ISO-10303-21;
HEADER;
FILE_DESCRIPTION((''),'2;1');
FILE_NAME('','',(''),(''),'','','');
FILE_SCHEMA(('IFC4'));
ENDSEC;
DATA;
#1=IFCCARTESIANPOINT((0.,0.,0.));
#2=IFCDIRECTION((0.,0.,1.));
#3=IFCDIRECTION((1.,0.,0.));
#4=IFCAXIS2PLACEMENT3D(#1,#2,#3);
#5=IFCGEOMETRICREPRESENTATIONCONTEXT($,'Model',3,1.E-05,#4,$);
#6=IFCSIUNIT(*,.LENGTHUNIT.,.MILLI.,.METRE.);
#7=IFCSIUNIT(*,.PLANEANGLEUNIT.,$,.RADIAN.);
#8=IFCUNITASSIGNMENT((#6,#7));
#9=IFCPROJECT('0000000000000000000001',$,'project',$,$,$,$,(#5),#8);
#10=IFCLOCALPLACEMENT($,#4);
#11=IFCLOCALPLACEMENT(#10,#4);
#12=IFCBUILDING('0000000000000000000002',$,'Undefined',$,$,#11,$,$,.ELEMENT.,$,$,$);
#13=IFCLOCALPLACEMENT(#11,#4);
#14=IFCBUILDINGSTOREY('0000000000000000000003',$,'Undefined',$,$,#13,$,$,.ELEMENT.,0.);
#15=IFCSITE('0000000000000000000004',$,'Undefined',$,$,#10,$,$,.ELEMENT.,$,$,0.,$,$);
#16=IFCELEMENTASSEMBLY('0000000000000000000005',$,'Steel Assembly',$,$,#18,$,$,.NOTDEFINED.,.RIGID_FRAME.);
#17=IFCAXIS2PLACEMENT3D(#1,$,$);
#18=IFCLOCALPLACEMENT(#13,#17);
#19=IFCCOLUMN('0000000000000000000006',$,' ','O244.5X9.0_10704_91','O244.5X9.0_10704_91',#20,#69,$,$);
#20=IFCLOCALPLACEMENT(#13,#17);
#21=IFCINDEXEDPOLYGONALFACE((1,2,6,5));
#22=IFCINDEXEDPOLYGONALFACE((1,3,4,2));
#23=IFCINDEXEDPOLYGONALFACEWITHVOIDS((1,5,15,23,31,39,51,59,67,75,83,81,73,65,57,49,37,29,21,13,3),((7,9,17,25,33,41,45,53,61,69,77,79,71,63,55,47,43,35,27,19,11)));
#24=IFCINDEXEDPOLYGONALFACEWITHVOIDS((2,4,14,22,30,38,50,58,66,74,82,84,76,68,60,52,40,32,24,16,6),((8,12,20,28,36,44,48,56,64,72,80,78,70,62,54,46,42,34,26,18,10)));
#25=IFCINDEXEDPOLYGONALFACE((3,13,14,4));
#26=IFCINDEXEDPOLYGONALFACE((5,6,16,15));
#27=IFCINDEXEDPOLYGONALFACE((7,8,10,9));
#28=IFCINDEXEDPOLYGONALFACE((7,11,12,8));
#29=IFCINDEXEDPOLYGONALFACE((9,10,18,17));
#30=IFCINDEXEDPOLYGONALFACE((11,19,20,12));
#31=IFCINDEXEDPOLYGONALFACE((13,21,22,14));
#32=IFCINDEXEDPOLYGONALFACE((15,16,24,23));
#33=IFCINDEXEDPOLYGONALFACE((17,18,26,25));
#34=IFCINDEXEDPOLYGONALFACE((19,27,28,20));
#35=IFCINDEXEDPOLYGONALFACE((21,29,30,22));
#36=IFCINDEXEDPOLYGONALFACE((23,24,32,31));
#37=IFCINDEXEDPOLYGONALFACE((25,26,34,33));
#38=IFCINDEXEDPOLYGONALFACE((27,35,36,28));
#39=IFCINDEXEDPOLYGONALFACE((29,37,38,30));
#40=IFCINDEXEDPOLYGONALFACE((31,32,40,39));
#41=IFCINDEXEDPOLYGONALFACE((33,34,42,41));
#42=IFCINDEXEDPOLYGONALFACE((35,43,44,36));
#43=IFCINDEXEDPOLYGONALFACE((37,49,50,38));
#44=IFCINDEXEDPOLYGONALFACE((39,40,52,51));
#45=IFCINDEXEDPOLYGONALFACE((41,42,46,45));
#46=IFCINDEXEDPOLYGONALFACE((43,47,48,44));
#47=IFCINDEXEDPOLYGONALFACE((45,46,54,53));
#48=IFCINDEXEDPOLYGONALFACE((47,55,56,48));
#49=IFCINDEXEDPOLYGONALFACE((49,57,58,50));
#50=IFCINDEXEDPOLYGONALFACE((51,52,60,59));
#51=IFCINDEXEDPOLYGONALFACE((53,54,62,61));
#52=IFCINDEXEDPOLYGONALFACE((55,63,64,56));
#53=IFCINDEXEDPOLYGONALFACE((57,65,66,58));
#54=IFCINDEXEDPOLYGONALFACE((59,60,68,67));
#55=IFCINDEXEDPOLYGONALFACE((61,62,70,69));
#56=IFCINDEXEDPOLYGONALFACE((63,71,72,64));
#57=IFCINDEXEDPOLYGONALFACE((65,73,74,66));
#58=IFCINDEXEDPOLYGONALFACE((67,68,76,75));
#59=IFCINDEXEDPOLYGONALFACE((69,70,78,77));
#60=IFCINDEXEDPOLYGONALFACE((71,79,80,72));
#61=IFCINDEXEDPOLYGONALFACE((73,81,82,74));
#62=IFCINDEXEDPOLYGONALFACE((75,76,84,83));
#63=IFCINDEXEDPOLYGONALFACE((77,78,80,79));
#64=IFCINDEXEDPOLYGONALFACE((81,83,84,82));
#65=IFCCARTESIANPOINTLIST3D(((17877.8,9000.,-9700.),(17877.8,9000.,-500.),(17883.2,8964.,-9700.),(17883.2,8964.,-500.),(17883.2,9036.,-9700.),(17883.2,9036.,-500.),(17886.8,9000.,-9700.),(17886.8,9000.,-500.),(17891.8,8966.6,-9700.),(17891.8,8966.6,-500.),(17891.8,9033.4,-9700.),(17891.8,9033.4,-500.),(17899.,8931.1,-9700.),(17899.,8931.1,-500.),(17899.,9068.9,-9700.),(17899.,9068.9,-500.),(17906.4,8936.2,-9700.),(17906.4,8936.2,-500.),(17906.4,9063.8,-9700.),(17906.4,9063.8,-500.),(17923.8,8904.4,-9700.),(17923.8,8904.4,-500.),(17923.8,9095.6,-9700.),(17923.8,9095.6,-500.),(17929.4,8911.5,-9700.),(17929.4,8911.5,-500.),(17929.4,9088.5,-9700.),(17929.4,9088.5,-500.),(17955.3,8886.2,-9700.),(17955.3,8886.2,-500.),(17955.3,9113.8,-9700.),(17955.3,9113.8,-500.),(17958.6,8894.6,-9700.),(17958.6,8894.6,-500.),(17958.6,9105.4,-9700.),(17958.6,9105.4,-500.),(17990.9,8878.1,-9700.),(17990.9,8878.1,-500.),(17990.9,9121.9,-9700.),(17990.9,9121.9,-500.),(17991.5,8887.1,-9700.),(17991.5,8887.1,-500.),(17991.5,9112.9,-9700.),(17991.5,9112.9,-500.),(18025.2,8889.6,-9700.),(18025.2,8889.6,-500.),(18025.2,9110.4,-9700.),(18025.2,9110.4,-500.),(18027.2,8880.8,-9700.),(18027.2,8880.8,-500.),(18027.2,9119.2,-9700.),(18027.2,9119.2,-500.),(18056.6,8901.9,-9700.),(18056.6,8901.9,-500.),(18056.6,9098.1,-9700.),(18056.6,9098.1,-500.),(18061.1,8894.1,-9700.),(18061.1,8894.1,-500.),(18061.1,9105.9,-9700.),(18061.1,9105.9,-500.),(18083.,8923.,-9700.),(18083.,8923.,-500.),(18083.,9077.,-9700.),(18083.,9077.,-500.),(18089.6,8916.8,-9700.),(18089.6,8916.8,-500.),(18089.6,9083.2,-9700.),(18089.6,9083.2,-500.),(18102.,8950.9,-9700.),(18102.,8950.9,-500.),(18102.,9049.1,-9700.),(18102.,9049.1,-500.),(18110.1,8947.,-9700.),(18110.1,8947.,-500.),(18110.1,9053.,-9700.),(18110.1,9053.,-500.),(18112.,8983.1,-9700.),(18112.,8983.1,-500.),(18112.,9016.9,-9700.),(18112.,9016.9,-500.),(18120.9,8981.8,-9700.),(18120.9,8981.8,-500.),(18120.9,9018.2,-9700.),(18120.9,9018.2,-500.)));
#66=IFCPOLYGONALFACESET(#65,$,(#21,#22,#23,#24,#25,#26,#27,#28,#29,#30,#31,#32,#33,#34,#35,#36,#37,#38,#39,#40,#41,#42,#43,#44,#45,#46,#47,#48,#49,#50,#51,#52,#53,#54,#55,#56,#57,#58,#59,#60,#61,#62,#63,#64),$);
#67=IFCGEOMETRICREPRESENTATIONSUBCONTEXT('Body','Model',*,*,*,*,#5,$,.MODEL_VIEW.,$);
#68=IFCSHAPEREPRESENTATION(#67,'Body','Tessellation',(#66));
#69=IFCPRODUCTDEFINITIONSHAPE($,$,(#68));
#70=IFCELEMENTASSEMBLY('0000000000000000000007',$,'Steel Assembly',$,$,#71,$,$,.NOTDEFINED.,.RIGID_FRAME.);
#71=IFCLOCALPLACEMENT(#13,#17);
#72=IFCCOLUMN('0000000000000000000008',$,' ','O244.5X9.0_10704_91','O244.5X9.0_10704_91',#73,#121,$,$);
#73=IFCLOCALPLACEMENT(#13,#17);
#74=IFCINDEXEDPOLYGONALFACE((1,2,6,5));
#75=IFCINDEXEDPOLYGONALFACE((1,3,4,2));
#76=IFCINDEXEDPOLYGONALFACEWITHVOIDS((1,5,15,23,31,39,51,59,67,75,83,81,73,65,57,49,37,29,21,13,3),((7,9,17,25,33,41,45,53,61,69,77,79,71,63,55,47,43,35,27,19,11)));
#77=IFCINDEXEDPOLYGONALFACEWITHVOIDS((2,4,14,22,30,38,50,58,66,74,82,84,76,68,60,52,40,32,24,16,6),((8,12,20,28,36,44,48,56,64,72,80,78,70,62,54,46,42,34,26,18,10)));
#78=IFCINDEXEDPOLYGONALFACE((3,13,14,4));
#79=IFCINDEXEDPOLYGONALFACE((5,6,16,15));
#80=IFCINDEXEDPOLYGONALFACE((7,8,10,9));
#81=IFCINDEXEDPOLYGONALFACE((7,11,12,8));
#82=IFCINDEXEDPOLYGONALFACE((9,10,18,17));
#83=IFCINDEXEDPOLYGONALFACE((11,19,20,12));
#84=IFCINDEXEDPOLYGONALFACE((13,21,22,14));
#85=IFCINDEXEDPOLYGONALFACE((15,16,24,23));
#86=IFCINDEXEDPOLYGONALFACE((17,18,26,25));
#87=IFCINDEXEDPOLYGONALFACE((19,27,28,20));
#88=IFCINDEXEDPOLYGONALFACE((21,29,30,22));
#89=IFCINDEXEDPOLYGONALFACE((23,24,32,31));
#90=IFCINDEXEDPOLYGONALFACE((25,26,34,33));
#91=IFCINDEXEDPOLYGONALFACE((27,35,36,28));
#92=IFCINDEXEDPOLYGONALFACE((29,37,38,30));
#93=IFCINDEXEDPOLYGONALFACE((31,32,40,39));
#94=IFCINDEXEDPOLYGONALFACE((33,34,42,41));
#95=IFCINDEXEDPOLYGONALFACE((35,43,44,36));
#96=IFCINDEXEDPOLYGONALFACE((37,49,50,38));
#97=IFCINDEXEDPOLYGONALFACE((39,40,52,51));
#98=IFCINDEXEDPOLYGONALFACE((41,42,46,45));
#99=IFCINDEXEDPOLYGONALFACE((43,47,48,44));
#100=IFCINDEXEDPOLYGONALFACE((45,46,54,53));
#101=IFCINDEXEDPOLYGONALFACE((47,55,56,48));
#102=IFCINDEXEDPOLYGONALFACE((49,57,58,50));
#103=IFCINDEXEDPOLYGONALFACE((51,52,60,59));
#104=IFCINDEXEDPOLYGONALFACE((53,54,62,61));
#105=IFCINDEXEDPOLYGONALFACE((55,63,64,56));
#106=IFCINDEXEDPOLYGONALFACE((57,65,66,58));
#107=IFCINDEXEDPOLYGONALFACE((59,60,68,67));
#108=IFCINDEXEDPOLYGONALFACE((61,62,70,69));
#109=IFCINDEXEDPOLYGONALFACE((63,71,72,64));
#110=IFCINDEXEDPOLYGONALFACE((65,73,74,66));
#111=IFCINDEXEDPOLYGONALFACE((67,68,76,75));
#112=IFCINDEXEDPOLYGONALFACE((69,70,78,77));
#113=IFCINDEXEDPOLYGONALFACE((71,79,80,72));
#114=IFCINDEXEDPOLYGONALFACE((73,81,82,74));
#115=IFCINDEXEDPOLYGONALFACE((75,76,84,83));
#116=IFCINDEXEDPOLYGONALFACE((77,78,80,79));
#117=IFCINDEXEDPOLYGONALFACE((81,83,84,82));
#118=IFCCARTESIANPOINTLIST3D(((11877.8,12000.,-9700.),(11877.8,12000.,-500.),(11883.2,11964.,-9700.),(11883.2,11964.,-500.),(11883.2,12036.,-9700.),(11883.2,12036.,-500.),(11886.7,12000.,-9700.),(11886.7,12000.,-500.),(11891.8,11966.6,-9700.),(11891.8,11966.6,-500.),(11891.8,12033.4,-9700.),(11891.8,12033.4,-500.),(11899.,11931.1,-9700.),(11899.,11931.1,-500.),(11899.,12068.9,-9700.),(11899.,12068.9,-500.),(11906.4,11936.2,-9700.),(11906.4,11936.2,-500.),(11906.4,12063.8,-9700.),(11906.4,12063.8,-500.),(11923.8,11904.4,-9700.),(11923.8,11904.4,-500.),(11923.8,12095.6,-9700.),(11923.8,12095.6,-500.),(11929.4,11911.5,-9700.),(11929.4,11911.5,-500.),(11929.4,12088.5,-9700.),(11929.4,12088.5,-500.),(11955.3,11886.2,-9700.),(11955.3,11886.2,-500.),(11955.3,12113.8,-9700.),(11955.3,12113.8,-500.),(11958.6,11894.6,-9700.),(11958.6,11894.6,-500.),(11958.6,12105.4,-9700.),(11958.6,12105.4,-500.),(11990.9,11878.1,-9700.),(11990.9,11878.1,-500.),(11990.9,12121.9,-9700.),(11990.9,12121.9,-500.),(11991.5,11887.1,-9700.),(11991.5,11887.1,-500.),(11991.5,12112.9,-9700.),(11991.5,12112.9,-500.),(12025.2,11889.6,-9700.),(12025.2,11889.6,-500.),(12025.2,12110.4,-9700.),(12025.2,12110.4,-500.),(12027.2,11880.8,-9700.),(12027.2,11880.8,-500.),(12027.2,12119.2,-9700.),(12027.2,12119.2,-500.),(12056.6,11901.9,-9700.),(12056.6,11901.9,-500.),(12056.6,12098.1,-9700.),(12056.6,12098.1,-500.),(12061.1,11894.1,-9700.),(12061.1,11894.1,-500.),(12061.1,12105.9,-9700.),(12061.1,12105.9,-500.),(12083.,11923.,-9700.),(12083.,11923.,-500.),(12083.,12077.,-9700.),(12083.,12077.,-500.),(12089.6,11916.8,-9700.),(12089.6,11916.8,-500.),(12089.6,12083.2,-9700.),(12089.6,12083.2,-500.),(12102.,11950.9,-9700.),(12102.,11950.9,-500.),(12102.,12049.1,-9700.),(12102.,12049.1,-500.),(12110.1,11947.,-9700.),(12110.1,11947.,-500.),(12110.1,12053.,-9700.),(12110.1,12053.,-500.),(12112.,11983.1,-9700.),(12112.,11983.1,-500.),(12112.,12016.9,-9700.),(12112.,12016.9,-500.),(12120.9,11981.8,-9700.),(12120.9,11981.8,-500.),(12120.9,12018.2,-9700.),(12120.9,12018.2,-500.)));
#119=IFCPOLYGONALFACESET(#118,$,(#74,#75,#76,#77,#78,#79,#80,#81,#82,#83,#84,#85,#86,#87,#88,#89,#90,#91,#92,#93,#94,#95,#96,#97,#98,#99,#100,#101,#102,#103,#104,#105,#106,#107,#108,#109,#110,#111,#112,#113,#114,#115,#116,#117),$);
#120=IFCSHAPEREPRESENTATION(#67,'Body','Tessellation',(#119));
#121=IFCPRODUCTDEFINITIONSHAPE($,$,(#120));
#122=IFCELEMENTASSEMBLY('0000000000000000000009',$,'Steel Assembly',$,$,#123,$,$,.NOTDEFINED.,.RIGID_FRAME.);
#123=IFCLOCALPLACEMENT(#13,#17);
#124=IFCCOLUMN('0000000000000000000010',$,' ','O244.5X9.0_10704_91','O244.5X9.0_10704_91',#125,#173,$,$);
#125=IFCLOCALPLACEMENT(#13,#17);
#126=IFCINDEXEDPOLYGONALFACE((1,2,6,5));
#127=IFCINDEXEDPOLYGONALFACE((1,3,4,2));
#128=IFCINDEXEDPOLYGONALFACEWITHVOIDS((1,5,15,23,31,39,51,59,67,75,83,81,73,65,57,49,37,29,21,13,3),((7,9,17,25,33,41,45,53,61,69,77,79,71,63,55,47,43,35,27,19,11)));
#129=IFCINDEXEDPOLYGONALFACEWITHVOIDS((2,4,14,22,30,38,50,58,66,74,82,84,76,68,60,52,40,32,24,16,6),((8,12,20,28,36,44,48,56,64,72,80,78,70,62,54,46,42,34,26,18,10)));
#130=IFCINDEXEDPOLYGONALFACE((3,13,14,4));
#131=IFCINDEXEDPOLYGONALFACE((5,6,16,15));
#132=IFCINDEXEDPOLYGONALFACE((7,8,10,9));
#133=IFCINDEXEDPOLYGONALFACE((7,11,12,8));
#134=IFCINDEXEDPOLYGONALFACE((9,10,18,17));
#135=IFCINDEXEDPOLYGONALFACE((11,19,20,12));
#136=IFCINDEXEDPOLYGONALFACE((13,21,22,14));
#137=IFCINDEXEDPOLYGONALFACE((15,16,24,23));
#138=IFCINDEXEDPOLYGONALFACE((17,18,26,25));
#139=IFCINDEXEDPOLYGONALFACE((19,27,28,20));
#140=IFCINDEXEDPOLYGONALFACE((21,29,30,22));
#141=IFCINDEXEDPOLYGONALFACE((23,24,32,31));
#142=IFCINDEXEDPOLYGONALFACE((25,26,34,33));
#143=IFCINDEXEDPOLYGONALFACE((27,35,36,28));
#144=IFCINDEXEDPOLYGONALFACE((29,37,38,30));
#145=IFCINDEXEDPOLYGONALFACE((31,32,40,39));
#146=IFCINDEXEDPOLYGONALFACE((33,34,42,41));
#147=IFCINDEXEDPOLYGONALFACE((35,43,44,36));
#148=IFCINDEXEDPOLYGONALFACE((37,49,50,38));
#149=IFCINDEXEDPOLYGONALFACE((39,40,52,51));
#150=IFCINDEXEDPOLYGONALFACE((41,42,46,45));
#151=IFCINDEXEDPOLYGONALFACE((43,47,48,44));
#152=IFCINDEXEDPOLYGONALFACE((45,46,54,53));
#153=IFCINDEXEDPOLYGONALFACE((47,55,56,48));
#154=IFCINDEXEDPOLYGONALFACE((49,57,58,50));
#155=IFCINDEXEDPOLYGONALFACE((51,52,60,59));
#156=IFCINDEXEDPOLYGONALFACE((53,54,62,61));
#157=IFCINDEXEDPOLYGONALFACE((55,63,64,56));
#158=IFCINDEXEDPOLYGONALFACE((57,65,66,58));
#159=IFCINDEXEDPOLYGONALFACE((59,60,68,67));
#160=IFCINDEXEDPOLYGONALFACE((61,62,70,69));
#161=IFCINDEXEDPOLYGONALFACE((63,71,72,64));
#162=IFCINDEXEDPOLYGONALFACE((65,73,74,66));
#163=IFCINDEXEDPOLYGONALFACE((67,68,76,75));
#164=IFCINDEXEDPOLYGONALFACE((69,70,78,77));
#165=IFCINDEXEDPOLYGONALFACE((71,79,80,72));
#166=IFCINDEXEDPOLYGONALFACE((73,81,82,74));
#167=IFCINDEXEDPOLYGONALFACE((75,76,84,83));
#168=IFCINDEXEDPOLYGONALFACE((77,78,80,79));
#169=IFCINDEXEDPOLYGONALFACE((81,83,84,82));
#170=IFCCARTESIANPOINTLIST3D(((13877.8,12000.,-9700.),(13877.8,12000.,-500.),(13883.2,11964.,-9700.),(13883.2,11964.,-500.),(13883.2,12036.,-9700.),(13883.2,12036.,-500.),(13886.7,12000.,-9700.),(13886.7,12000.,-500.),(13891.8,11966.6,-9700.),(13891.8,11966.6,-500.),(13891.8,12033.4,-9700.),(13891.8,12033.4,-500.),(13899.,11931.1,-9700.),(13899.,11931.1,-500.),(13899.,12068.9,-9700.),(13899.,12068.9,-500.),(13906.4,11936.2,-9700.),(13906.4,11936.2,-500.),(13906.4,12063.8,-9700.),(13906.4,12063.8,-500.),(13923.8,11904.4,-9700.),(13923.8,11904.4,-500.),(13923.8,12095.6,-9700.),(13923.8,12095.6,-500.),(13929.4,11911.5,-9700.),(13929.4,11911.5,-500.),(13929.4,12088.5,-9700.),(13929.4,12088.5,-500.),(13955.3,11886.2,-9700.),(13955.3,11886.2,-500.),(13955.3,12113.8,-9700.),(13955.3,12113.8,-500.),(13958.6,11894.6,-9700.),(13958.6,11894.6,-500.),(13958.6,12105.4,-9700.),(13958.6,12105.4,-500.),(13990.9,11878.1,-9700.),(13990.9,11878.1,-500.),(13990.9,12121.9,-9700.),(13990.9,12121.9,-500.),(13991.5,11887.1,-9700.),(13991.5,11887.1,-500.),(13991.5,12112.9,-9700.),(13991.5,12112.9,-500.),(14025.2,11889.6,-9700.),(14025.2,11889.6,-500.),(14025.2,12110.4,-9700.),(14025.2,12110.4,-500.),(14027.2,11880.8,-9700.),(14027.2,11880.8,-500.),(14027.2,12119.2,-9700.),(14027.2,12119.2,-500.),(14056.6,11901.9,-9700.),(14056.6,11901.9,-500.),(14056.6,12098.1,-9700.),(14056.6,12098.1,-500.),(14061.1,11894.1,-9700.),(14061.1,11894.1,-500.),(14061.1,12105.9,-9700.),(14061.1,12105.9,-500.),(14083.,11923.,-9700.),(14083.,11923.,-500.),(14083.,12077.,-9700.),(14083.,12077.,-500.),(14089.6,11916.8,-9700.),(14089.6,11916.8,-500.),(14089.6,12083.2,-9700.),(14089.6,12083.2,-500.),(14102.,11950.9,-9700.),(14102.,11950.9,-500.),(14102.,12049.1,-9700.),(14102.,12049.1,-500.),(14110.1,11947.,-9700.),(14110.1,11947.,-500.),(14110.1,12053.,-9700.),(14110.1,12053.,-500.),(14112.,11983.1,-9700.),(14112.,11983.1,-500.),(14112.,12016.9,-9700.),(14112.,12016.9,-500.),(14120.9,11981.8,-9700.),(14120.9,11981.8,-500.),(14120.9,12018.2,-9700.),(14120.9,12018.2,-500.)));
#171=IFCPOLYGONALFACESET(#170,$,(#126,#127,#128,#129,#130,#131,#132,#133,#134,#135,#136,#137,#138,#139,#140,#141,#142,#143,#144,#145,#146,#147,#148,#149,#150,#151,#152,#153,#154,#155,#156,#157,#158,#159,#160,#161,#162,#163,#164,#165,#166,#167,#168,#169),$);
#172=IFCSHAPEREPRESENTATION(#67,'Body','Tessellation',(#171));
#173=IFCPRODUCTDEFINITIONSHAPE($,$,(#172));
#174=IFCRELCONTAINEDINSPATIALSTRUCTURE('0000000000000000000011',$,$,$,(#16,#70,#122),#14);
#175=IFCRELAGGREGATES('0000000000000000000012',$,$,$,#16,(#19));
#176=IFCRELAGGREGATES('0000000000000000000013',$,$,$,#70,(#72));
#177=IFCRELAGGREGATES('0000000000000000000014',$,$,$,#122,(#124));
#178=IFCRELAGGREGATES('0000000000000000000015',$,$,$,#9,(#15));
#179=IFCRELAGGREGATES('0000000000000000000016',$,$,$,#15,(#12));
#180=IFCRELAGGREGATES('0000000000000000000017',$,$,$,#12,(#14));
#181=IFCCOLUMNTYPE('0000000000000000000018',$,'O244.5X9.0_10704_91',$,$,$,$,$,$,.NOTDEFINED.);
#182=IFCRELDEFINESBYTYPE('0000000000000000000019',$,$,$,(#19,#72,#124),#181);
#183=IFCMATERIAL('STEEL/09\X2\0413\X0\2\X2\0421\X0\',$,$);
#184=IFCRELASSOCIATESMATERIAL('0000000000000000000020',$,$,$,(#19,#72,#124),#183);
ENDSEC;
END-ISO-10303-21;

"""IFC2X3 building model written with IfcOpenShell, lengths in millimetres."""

from ifc_helpers import new_model, si_unit, frame, origin_with_axes, origin_2d_with_axis, place, context, subcontext, project, spatial, hollow_circle, extrude, material, type_object, element, aggregate, save


model = new_model("IFC2X3")

# Units and contexts
model_context = context("Model", 3, precision=1e-05, world=origin_with_axes())
body_context = subcontext(model_context, "Body", "Model", "MODEL_VIEW")
ifc_project = project(units=[si_unit("LENGTHUNIT", "METRE", prefix="MILLI"), si_unit("PLANEANGLEUNIT", "RADIAN")], contexts=[model_context])

# Site, building, storey
site_placement = place(None, origin_with_axes())
site = spatial("IfcSite", under=ifc_project, at=site_placement, Name="Undefined", CompositionType="ELEMENT", RefElevation=0.0)
building_placement = place(site_placement, origin_with_axes())
building = spatial("IfcBuilding", under=site, at=building_placement, Name="Undefined", CompositionType="ELEMENT")
storey_placement = place(building_placement, origin_with_axes())
storey = spatial("IfcBuildingStorey", under=building, at=storey_placement, Name="Undefined", CompositionType="ELEMENT", Elevation=0.0)

# Element assemblies, columns
ifc_material_1 = material(Name="STEEL/09Г2С")
column_type_1 = type_object("IfcColumnType", Name="O244.5X9.0_10704_91", PredefinedType="NOTDEFINED")
assembly_1_placement = place(storey_placement, origin_with_axes())
assembly_1 = element("IfcElementAssembly", 1, at=assembly_1_placement, inside=storey, Name="Steel Assembly", AssemblyPlace="NOTDEFINED", PredefinedType="RIGID_FRAME")
column_1_placement = place(assembly_1_placement, frame((18000.0, 9000.0, -9700.0), z_axis=(0.0, 0.0, 1.0), x_axis=(0.0, 1.0, 0.0)))
column_1 = element("IfcColumn", 2, at=column_1_placement, type_object=column_type_1, material=ifc_material_1, Name=" ", Description="O244.5X9.0_10704_91", ObjectType="O244.5X9.0_10704_91", context=body_context, shape_type="SweptSolid", body=[
    extrude(hollow_circle(Radius=122.2, WallThickness=9.0, at=origin_2d_with_axis()), frame((0.0, 0.0, 9200.0), z_axis=(0.0, 0.0, -1.0), x_axis=(0.0, 1.0, 0.0)), (0.0, 0.0, 1.0), 9200.0),
])
aggregate(assembly_1, [column_1])
assembly_2_placement = place(storey_placement, origin_with_axes())
assembly_2 = element("IfcElementAssembly", 3, at=assembly_2_placement, inside=storey, Name="Steel Assembly", AssemblyPlace="NOTDEFINED", PredefinedType="RIGID_FRAME")
column_2_placement = place(assembly_2_placement, frame((12000.0, 12000.0, -9700.0), z_axis=(0.0, 0.0, 1.0), x_axis=(0.0, 1.0, 0.0)))
column_2 = element("IfcColumn", 4, at=column_2_placement, type_object=column_type_1, material=ifc_material_1, Name=" ", Description="O244.5X9.0_10704_91", ObjectType="O244.5X9.0_10704_91", context=body_context, shape_type="SweptSolid", body=[
    extrude(hollow_circle(Radius=122.2, WallThickness=9.0, at=origin_2d_with_axis()), frame((0.0, 0.0, 9200.0), z_axis=(0.0, 0.0, -1.0), x_axis=(0.0, 1.0, 0.0)), (0.0, 0.0, 1.0), 9200.0),
])
aggregate(assembly_2, [column_2])
assembly_3_placement = place(storey_placement, origin_with_axes())
assembly_3 = element("IfcElementAssembly", 5, at=assembly_3_placement, inside=storey, Name="Steel Assembly", AssemblyPlace="NOTDEFINED", PredefinedType="RIGID_FRAME")
column_3_placement = place(assembly_3_placement, frame((14000.0, 12000.0, -9700.0), z_axis=(0.0, 0.0, 1.0), x_axis=(0.0, 1.0, 0.0)))
column_3 = element("IfcColumn", 6, at=column_3_placement, type_object=column_type_1, material=ifc_material_1, Name=" ", Description="O244.5X9.0_10704_91", ObjectType="O244.5X9.0_10704_91", context=body_context, shape_type="SweptSolid", body=[
    extrude(hollow_circle(Radius=122.2, WallThickness=9.0, at=origin_2d_with_axis()), frame((0.0, 0.0, 9200.0), z_axis=(0.0, 0.0, -1.0), x_axis=(0.0, 1.0, 0.0)), (0.0, 0.0, 1.0), 9200.0),
])
aggregate(assembly_3, [column_3])

save(model, "model.ifc")
